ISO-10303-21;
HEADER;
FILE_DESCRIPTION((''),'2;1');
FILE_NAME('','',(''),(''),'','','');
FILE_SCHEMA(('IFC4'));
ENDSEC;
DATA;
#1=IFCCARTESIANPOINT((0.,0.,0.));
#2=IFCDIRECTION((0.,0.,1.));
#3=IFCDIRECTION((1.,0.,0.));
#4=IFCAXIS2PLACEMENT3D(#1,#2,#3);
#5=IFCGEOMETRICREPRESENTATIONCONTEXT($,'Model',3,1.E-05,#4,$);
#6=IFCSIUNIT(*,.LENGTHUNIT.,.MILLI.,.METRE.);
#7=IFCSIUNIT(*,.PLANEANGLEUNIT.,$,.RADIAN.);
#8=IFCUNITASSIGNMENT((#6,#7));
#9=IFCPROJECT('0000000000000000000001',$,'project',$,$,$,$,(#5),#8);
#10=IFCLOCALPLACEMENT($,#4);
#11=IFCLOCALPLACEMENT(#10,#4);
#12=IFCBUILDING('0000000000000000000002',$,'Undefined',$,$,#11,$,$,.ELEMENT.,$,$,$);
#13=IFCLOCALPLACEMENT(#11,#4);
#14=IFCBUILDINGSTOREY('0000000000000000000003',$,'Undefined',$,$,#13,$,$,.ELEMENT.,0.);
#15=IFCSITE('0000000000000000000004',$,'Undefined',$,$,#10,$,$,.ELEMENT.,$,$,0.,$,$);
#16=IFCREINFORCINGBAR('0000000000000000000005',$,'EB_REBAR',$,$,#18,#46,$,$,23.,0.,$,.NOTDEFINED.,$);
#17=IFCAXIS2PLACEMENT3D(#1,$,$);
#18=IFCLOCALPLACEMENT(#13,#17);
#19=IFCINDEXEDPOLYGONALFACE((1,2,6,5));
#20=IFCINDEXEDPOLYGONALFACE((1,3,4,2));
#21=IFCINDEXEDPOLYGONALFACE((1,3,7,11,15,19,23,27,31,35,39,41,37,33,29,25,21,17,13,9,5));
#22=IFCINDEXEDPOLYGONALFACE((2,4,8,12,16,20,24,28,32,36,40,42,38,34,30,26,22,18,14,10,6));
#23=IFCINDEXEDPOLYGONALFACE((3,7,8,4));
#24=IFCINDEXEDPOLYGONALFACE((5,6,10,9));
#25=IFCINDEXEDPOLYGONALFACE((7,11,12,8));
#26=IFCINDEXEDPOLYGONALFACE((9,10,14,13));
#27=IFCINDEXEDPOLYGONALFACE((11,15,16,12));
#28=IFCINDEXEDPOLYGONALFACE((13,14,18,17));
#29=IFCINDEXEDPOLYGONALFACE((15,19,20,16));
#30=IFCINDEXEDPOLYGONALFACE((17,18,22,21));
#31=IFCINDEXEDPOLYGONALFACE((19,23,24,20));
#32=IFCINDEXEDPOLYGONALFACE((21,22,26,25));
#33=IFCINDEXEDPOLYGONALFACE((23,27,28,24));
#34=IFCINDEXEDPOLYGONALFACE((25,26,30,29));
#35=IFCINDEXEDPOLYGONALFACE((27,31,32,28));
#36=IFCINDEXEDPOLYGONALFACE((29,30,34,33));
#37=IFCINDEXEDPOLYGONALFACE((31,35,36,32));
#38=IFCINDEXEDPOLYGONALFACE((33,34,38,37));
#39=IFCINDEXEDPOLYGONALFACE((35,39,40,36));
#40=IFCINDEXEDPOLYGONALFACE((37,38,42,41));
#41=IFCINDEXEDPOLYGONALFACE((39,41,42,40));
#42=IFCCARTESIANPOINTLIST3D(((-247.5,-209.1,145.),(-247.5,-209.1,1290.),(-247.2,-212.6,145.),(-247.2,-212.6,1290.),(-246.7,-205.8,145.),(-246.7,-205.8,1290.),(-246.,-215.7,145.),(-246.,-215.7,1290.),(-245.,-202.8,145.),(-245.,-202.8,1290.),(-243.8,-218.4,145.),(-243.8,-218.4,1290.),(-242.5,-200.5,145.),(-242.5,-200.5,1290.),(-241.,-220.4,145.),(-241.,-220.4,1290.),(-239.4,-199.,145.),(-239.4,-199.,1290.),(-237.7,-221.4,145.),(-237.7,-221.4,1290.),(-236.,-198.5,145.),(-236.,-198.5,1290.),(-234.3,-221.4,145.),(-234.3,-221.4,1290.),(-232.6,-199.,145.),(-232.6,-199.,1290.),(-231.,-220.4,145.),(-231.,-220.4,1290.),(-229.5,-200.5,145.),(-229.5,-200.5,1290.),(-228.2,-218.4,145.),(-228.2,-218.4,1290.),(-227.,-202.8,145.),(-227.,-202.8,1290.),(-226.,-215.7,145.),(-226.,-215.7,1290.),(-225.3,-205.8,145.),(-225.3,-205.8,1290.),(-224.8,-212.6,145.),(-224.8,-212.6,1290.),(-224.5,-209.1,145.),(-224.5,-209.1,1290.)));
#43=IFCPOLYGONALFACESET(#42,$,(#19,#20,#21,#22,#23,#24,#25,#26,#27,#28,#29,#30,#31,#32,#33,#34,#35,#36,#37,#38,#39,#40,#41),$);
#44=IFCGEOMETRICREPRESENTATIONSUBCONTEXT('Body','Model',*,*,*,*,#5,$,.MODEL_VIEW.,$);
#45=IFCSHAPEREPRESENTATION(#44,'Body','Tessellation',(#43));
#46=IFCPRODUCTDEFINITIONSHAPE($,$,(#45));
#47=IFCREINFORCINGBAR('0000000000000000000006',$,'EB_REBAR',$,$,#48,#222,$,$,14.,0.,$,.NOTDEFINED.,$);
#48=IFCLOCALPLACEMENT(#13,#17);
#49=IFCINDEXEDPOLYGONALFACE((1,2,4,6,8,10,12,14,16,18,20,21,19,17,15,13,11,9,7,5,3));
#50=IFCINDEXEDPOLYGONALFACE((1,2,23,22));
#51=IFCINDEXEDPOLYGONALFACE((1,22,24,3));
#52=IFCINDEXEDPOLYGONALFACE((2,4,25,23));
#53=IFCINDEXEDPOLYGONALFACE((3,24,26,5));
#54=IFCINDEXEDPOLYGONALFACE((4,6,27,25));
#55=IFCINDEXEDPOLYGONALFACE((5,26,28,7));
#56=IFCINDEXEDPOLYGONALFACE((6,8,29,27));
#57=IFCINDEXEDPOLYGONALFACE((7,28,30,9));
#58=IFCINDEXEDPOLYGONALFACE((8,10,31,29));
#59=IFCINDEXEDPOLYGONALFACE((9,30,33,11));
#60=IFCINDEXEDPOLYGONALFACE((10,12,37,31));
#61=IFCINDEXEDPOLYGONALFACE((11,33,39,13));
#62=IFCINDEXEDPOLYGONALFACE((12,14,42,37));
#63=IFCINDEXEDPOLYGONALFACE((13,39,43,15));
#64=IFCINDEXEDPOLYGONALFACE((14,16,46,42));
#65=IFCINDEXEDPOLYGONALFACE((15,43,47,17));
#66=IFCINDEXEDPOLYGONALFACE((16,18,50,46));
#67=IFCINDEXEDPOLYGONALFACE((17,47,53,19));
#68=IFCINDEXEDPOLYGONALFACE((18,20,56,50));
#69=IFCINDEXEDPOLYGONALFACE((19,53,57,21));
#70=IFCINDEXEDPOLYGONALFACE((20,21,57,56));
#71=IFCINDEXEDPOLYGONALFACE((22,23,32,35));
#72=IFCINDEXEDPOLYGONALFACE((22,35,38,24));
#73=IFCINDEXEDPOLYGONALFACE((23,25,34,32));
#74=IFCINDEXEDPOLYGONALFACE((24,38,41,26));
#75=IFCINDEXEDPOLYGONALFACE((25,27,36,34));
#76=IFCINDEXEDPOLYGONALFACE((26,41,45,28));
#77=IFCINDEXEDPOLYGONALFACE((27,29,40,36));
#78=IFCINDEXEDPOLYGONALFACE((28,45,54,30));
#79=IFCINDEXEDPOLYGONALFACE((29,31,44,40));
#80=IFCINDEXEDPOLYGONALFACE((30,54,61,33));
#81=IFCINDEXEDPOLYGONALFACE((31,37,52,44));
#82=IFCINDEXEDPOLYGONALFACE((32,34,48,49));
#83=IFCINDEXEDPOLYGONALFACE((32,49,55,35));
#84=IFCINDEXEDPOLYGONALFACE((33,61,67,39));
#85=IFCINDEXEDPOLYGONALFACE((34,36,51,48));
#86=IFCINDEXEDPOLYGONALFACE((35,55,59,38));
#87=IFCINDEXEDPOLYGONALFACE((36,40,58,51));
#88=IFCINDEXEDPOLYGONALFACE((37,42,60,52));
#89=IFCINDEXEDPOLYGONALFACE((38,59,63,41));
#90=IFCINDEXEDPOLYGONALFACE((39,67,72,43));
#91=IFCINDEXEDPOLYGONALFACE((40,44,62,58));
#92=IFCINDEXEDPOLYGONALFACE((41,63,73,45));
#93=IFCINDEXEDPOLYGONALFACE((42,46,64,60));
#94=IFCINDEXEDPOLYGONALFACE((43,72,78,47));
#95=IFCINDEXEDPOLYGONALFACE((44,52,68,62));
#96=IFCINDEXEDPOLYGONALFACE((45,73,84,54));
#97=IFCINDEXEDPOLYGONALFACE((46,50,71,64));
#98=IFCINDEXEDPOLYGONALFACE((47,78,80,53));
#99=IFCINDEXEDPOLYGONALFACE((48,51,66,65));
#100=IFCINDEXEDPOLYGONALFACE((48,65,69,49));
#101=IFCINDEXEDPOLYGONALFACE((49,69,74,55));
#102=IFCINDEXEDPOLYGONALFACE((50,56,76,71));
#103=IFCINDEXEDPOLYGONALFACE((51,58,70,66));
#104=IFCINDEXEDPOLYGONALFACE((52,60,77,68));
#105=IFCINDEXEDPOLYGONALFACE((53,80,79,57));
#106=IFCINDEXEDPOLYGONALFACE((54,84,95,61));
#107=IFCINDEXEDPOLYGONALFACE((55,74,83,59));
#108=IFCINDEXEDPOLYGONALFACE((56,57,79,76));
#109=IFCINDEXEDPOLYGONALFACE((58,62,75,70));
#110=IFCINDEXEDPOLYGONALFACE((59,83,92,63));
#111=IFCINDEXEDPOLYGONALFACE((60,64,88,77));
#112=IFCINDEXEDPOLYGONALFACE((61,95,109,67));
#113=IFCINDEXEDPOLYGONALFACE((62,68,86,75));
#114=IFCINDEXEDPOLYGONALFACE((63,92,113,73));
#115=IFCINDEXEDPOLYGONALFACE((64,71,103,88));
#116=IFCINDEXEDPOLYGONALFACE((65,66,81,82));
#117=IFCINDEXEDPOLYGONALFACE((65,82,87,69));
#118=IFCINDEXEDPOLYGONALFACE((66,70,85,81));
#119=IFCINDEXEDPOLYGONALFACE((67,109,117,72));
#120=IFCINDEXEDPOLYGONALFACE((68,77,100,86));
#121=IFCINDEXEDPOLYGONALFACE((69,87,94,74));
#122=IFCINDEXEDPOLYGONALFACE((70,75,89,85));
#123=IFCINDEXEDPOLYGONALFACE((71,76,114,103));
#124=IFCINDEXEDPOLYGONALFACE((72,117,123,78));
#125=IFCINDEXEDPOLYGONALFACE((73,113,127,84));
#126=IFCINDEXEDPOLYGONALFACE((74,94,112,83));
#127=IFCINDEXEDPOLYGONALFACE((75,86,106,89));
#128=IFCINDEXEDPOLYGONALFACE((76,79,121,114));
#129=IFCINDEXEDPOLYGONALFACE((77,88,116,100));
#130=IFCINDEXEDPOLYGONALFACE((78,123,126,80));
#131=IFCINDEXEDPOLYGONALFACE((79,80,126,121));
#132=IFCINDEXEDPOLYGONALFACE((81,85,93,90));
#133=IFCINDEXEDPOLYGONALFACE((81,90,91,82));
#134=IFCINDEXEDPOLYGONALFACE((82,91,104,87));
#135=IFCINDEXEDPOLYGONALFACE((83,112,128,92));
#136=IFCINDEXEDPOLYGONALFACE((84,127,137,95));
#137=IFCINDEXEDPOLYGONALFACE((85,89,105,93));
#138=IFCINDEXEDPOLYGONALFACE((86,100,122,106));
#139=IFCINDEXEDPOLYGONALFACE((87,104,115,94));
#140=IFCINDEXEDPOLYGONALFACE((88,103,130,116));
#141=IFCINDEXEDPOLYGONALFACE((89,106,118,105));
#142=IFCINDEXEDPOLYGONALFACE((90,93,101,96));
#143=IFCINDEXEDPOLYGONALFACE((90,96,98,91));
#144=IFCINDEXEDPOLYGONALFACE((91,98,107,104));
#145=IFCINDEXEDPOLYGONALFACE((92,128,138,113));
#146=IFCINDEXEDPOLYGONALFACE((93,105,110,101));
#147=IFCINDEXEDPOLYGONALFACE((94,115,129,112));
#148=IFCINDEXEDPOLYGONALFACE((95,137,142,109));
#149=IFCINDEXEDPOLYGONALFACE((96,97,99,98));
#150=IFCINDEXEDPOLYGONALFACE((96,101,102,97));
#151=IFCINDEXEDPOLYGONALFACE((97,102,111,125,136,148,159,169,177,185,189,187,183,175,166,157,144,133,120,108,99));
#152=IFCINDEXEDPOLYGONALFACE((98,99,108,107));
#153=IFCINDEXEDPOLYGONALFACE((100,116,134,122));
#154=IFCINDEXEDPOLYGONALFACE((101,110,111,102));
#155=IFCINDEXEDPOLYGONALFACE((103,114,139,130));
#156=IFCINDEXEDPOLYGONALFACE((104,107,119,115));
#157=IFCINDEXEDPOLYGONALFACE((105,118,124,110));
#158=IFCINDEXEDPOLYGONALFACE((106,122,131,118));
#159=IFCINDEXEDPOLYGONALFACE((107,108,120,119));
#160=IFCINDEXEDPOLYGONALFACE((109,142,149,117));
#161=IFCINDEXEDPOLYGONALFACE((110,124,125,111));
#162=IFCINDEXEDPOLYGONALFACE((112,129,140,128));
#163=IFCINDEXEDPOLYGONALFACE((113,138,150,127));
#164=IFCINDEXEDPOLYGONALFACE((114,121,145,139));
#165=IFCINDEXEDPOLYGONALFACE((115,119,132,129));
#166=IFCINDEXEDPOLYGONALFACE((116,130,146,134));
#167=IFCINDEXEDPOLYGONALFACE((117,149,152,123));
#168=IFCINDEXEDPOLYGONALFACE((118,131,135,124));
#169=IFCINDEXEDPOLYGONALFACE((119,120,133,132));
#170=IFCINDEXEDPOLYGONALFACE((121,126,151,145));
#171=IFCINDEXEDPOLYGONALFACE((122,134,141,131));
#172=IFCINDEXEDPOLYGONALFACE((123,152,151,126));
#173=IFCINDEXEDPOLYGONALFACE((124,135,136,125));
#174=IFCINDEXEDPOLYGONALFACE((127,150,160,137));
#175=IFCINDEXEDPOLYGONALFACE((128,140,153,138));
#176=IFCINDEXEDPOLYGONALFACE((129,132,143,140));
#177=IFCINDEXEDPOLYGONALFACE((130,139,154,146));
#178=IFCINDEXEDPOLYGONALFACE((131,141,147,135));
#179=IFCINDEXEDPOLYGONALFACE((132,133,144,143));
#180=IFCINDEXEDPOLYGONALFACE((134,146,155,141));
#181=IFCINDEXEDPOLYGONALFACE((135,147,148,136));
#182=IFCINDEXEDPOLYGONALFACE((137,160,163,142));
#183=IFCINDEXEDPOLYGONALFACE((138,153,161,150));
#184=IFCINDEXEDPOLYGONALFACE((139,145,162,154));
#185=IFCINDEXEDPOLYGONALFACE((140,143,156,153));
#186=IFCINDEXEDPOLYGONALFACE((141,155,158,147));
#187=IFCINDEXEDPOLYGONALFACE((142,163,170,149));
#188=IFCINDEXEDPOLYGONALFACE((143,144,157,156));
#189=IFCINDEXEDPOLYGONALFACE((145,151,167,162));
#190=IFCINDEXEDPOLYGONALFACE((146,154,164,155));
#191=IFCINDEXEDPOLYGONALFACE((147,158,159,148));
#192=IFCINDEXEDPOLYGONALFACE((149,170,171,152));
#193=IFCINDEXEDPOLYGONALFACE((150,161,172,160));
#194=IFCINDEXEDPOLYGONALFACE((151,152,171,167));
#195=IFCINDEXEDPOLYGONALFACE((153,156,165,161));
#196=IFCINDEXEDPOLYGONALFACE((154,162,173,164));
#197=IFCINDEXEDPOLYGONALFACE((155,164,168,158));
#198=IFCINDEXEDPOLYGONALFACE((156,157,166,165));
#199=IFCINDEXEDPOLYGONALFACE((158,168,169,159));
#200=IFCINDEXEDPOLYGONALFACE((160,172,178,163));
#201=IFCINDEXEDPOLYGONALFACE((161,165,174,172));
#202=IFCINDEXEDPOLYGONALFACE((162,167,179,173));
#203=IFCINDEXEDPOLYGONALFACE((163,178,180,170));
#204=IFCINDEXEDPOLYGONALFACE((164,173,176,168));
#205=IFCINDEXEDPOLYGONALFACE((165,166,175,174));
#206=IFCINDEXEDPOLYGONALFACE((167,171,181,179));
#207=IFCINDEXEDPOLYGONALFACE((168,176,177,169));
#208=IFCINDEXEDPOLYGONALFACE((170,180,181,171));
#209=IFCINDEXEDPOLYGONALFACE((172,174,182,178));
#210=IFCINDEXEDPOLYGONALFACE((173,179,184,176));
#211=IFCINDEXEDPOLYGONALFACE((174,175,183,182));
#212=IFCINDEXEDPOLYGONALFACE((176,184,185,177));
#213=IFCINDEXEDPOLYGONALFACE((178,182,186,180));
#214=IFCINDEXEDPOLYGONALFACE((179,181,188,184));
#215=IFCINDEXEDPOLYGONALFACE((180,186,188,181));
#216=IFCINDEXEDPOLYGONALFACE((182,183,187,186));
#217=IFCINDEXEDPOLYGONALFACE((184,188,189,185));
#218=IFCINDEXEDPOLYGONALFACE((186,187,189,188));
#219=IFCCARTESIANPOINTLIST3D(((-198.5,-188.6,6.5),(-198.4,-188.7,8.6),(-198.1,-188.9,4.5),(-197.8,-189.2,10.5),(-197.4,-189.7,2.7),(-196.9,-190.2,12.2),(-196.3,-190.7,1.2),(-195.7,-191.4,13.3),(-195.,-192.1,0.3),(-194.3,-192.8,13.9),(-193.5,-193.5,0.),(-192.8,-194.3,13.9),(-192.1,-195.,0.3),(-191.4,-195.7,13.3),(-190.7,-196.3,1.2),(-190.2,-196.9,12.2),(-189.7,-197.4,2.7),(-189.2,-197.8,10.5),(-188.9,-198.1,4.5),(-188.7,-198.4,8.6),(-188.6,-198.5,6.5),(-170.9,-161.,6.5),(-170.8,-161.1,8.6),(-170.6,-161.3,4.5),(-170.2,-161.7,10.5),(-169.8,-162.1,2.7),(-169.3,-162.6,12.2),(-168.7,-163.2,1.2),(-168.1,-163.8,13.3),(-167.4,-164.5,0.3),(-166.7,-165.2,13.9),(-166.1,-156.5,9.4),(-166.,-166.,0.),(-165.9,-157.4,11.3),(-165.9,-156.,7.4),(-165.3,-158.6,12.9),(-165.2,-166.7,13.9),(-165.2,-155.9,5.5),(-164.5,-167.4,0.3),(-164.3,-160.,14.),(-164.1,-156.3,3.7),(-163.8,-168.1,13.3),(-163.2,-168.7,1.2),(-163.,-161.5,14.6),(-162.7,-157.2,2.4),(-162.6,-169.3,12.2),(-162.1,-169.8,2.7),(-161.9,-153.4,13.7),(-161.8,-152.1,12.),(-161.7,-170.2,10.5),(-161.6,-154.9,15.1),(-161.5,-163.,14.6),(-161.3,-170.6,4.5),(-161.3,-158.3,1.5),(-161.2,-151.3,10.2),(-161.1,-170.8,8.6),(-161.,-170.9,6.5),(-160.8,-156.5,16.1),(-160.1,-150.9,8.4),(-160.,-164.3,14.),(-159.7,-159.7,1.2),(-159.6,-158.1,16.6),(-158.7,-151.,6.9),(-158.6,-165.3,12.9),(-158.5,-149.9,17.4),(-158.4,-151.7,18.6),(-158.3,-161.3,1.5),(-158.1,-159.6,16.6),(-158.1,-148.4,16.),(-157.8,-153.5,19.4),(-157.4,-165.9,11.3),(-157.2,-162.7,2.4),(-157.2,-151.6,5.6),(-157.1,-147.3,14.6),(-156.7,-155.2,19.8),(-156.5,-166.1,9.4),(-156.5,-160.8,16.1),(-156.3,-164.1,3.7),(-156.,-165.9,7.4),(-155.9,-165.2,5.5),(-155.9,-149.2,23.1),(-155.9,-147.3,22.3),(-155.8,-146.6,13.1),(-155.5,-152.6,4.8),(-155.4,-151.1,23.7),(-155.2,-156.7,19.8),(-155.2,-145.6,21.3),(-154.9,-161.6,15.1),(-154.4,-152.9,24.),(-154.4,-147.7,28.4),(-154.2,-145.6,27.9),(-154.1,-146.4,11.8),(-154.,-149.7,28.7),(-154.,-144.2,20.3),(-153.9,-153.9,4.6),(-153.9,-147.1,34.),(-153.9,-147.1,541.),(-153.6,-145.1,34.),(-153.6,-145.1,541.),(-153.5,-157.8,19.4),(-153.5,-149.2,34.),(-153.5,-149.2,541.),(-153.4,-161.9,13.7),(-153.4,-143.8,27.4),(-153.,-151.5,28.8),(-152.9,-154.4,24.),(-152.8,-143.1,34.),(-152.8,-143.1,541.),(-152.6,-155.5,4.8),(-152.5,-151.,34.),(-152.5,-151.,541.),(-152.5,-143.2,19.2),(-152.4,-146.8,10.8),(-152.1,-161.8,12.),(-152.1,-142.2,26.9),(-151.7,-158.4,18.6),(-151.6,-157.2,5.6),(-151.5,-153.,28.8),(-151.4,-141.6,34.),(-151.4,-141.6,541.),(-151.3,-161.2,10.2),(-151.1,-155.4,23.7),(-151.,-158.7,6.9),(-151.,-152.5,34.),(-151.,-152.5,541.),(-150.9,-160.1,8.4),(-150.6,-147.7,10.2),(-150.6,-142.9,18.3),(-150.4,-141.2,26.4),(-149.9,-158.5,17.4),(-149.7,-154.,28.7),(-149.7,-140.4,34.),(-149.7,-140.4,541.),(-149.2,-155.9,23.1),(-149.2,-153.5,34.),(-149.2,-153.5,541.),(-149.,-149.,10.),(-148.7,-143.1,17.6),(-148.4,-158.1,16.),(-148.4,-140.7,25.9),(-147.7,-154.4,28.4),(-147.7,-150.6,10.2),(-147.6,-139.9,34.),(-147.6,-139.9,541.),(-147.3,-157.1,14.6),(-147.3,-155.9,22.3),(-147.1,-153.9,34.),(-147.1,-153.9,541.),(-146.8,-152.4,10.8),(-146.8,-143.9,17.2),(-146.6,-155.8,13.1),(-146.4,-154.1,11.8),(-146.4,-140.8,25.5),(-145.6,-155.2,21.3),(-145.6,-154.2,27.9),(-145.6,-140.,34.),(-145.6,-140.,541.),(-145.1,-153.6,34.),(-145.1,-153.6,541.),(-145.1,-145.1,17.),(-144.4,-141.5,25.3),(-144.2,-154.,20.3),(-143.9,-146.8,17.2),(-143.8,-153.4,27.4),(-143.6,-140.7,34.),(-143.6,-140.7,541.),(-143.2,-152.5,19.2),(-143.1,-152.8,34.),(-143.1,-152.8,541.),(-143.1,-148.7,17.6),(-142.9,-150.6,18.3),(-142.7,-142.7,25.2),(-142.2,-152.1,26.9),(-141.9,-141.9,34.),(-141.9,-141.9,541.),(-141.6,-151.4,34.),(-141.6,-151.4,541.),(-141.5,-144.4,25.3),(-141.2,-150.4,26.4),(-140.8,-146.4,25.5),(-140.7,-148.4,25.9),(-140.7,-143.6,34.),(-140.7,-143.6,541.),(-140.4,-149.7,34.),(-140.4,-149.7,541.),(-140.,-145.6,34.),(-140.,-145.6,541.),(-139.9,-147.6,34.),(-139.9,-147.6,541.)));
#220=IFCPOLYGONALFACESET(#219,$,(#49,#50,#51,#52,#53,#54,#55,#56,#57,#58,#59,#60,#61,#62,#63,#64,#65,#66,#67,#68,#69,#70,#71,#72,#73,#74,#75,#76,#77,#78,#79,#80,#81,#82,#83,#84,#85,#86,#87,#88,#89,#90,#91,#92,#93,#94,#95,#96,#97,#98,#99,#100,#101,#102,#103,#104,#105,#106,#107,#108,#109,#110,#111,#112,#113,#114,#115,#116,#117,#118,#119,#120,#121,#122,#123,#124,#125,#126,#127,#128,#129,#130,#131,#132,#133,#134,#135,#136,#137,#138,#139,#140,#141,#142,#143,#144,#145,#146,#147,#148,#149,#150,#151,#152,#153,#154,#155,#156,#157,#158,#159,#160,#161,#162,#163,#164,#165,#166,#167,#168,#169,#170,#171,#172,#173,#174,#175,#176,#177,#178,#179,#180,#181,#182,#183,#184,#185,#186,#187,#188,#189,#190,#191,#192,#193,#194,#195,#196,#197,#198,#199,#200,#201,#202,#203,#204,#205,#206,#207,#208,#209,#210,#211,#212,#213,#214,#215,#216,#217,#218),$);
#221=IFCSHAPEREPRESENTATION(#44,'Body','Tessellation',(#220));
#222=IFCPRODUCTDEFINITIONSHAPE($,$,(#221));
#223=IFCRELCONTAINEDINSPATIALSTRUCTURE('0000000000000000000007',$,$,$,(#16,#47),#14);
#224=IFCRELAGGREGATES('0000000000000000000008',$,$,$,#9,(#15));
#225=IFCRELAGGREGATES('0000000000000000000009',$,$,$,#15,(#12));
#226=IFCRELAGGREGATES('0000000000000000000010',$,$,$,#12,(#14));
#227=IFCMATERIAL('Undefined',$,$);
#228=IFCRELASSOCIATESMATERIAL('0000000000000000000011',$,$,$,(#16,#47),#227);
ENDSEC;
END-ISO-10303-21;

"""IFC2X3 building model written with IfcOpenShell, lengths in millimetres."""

from ifc_helpers import new_model, entity, si_unit, frame, origin_with_axes, place, context, subcontext, project, spatial, source, transform, mapped, material, element, save


model = new_model("IFC2X3")

# Units and contexts
model_context = context("Model", 3, precision=1e-05, world=origin_with_axes())
body_context = subcontext(model_context, "Body", "Model", "MODEL_VIEW")
ifc_project = project(units=[si_unit("LENGTHUNIT", "METRE", prefix="MILLI"), si_unit("PLANEANGLEUNIT", "RADIAN")], contexts=[model_context])

# Site, building, storey
site_placement = place(None, origin_with_axes())
site = spatial("IfcSite", under=ifc_project, at=site_placement, Name="Undefined", CompositionType="ELEMENT", RefElevation=0.0)
building_placement = place(site_placement, origin_with_axes())
building = spatial("IfcBuilding", under=site, at=building_placement, Name="Undefined", CompositionType="ELEMENT")
storey_placement = place(building_placement, origin_with_axes())
storey = spatial("IfcBuildingStorey", under=building, at=storey_placement, Name="Undefined", CompositionType="ELEMENT", Elevation=0.0)

# Reinforcing bars
ifc_material_1 = material(Name="Undefined")
shared_shape_1 = source(origin_with_axes(), body_context, "Body", "AdvancedSweptSolid", [
    entity("IfcSweptDiskSolid", entity("IfcTrimmedCurve", entity("IfcLine", entity("IfcCartesianPoint", [0.0, 0.0, 0.0]), entity("IfcVector", entity("IfcDirection", [1.0, 0.0, 0.0]), 1.0)), [entity("IfcParameterValue", 0.0)], [entity("IfcParameterValue", 1144.999996)], True, "PARAMETER"), 11.5, None, 0.0, 1145.0),
])
reinforcing_bar_1_placement = place(storey_placement, frame((-236.0, -210.0, 145.0), z_axis=(0.0, 1.0, 0.0), x_axis=(0.0, 0.0, 1.0)))
element("IfcReinforcingBar", 1, at=reinforcing_bar_1_placement, inside=storey, material=ifc_material_1, Name="EB_REBAR", BarRole="NOTDEFINED", CrossSectionArea=0.0, NominalDiameter=23.0, context=body_context, shape_type="MappedRepresentation", body=[
    mapped(shared_shape_1, transform((0.0, 0.0, 0.0))),
])
shared_shape_2 = source(origin_with_axes(), body_context, "Body", "AdvancedSweptSolid", [
    entity("IfcSweptDiskSolid", entity("IfcCompositeCurve", [entity("IfcCompositeCurveSegment", "CONTINUOUS", True, entity("IfcTrimmedCurve", entity("IfcLine", entity("IfcCartesianPoint", [0.0, 0.0, 0.0]), entity("IfcVector", entity("IfcDirection", [0.0, 0.0, -1.0]), 1.0)), [entity("IfcParameterValue", 0.0)], [entity("IfcParameterValue", 39.002617)], True, "PARAMETER")), entity("IfcCompositeCurveSegment", "CONTINUOUS", True, entity("IfcTrimmedCurve", entity("IfcCircle", entity("IfcAxis2Placement3D", entity("IfcCartesianPoint", [27.0, 0.0, -39.0]), entity("IfcDirection", [0.0, -1.0, 0.0]), entity("IfcDirection", [-1.0, 0.0, 0.0])), 27.0), [entity("IfcParameterValue", 0.0)], [entity("IfcParameterValue", 1.570797)], True, "PARAMETER")), entity("IfcCompositeCurveSegment", "DISCONTINUOUS", True, entity("IfcTrimmedCurve", entity("IfcLine", entity("IfcCartesianPoint", [27.0, 0.0, -66.0]), entity("IfcVector", entity("IfcDirection", [1.0, 0.0, 0.0]), 1.0)), [entity("IfcParameterValue", 0.0)], [entity("IfcParameterValue", 506.999983)], True, "PARAMETER"))], False), 7.0, None, 0.0, 547.6),
])
reinforcing_bar_2_placement = place(storey_placement, frame((-155.9, -155.9, 7.0), z_axis=(-0.707107, -0.707107, 0.000001), x_axis=(0.000001, 0.000001, 1.0)))
element("IfcReinforcingBar", 2, at=reinforcing_bar_2_placement, inside=storey, material=ifc_material_1, Name="EB_REBAR", BarRole="NOTDEFINED", CrossSectionArea=0.0, NominalDiameter=14.0, context=body_context, shape_type="MappedRepresentation", body=[
    mapped(shared_shape_2, transform((0.0, 0.0, 53.2))),
])

save(model, "model.ifc")
